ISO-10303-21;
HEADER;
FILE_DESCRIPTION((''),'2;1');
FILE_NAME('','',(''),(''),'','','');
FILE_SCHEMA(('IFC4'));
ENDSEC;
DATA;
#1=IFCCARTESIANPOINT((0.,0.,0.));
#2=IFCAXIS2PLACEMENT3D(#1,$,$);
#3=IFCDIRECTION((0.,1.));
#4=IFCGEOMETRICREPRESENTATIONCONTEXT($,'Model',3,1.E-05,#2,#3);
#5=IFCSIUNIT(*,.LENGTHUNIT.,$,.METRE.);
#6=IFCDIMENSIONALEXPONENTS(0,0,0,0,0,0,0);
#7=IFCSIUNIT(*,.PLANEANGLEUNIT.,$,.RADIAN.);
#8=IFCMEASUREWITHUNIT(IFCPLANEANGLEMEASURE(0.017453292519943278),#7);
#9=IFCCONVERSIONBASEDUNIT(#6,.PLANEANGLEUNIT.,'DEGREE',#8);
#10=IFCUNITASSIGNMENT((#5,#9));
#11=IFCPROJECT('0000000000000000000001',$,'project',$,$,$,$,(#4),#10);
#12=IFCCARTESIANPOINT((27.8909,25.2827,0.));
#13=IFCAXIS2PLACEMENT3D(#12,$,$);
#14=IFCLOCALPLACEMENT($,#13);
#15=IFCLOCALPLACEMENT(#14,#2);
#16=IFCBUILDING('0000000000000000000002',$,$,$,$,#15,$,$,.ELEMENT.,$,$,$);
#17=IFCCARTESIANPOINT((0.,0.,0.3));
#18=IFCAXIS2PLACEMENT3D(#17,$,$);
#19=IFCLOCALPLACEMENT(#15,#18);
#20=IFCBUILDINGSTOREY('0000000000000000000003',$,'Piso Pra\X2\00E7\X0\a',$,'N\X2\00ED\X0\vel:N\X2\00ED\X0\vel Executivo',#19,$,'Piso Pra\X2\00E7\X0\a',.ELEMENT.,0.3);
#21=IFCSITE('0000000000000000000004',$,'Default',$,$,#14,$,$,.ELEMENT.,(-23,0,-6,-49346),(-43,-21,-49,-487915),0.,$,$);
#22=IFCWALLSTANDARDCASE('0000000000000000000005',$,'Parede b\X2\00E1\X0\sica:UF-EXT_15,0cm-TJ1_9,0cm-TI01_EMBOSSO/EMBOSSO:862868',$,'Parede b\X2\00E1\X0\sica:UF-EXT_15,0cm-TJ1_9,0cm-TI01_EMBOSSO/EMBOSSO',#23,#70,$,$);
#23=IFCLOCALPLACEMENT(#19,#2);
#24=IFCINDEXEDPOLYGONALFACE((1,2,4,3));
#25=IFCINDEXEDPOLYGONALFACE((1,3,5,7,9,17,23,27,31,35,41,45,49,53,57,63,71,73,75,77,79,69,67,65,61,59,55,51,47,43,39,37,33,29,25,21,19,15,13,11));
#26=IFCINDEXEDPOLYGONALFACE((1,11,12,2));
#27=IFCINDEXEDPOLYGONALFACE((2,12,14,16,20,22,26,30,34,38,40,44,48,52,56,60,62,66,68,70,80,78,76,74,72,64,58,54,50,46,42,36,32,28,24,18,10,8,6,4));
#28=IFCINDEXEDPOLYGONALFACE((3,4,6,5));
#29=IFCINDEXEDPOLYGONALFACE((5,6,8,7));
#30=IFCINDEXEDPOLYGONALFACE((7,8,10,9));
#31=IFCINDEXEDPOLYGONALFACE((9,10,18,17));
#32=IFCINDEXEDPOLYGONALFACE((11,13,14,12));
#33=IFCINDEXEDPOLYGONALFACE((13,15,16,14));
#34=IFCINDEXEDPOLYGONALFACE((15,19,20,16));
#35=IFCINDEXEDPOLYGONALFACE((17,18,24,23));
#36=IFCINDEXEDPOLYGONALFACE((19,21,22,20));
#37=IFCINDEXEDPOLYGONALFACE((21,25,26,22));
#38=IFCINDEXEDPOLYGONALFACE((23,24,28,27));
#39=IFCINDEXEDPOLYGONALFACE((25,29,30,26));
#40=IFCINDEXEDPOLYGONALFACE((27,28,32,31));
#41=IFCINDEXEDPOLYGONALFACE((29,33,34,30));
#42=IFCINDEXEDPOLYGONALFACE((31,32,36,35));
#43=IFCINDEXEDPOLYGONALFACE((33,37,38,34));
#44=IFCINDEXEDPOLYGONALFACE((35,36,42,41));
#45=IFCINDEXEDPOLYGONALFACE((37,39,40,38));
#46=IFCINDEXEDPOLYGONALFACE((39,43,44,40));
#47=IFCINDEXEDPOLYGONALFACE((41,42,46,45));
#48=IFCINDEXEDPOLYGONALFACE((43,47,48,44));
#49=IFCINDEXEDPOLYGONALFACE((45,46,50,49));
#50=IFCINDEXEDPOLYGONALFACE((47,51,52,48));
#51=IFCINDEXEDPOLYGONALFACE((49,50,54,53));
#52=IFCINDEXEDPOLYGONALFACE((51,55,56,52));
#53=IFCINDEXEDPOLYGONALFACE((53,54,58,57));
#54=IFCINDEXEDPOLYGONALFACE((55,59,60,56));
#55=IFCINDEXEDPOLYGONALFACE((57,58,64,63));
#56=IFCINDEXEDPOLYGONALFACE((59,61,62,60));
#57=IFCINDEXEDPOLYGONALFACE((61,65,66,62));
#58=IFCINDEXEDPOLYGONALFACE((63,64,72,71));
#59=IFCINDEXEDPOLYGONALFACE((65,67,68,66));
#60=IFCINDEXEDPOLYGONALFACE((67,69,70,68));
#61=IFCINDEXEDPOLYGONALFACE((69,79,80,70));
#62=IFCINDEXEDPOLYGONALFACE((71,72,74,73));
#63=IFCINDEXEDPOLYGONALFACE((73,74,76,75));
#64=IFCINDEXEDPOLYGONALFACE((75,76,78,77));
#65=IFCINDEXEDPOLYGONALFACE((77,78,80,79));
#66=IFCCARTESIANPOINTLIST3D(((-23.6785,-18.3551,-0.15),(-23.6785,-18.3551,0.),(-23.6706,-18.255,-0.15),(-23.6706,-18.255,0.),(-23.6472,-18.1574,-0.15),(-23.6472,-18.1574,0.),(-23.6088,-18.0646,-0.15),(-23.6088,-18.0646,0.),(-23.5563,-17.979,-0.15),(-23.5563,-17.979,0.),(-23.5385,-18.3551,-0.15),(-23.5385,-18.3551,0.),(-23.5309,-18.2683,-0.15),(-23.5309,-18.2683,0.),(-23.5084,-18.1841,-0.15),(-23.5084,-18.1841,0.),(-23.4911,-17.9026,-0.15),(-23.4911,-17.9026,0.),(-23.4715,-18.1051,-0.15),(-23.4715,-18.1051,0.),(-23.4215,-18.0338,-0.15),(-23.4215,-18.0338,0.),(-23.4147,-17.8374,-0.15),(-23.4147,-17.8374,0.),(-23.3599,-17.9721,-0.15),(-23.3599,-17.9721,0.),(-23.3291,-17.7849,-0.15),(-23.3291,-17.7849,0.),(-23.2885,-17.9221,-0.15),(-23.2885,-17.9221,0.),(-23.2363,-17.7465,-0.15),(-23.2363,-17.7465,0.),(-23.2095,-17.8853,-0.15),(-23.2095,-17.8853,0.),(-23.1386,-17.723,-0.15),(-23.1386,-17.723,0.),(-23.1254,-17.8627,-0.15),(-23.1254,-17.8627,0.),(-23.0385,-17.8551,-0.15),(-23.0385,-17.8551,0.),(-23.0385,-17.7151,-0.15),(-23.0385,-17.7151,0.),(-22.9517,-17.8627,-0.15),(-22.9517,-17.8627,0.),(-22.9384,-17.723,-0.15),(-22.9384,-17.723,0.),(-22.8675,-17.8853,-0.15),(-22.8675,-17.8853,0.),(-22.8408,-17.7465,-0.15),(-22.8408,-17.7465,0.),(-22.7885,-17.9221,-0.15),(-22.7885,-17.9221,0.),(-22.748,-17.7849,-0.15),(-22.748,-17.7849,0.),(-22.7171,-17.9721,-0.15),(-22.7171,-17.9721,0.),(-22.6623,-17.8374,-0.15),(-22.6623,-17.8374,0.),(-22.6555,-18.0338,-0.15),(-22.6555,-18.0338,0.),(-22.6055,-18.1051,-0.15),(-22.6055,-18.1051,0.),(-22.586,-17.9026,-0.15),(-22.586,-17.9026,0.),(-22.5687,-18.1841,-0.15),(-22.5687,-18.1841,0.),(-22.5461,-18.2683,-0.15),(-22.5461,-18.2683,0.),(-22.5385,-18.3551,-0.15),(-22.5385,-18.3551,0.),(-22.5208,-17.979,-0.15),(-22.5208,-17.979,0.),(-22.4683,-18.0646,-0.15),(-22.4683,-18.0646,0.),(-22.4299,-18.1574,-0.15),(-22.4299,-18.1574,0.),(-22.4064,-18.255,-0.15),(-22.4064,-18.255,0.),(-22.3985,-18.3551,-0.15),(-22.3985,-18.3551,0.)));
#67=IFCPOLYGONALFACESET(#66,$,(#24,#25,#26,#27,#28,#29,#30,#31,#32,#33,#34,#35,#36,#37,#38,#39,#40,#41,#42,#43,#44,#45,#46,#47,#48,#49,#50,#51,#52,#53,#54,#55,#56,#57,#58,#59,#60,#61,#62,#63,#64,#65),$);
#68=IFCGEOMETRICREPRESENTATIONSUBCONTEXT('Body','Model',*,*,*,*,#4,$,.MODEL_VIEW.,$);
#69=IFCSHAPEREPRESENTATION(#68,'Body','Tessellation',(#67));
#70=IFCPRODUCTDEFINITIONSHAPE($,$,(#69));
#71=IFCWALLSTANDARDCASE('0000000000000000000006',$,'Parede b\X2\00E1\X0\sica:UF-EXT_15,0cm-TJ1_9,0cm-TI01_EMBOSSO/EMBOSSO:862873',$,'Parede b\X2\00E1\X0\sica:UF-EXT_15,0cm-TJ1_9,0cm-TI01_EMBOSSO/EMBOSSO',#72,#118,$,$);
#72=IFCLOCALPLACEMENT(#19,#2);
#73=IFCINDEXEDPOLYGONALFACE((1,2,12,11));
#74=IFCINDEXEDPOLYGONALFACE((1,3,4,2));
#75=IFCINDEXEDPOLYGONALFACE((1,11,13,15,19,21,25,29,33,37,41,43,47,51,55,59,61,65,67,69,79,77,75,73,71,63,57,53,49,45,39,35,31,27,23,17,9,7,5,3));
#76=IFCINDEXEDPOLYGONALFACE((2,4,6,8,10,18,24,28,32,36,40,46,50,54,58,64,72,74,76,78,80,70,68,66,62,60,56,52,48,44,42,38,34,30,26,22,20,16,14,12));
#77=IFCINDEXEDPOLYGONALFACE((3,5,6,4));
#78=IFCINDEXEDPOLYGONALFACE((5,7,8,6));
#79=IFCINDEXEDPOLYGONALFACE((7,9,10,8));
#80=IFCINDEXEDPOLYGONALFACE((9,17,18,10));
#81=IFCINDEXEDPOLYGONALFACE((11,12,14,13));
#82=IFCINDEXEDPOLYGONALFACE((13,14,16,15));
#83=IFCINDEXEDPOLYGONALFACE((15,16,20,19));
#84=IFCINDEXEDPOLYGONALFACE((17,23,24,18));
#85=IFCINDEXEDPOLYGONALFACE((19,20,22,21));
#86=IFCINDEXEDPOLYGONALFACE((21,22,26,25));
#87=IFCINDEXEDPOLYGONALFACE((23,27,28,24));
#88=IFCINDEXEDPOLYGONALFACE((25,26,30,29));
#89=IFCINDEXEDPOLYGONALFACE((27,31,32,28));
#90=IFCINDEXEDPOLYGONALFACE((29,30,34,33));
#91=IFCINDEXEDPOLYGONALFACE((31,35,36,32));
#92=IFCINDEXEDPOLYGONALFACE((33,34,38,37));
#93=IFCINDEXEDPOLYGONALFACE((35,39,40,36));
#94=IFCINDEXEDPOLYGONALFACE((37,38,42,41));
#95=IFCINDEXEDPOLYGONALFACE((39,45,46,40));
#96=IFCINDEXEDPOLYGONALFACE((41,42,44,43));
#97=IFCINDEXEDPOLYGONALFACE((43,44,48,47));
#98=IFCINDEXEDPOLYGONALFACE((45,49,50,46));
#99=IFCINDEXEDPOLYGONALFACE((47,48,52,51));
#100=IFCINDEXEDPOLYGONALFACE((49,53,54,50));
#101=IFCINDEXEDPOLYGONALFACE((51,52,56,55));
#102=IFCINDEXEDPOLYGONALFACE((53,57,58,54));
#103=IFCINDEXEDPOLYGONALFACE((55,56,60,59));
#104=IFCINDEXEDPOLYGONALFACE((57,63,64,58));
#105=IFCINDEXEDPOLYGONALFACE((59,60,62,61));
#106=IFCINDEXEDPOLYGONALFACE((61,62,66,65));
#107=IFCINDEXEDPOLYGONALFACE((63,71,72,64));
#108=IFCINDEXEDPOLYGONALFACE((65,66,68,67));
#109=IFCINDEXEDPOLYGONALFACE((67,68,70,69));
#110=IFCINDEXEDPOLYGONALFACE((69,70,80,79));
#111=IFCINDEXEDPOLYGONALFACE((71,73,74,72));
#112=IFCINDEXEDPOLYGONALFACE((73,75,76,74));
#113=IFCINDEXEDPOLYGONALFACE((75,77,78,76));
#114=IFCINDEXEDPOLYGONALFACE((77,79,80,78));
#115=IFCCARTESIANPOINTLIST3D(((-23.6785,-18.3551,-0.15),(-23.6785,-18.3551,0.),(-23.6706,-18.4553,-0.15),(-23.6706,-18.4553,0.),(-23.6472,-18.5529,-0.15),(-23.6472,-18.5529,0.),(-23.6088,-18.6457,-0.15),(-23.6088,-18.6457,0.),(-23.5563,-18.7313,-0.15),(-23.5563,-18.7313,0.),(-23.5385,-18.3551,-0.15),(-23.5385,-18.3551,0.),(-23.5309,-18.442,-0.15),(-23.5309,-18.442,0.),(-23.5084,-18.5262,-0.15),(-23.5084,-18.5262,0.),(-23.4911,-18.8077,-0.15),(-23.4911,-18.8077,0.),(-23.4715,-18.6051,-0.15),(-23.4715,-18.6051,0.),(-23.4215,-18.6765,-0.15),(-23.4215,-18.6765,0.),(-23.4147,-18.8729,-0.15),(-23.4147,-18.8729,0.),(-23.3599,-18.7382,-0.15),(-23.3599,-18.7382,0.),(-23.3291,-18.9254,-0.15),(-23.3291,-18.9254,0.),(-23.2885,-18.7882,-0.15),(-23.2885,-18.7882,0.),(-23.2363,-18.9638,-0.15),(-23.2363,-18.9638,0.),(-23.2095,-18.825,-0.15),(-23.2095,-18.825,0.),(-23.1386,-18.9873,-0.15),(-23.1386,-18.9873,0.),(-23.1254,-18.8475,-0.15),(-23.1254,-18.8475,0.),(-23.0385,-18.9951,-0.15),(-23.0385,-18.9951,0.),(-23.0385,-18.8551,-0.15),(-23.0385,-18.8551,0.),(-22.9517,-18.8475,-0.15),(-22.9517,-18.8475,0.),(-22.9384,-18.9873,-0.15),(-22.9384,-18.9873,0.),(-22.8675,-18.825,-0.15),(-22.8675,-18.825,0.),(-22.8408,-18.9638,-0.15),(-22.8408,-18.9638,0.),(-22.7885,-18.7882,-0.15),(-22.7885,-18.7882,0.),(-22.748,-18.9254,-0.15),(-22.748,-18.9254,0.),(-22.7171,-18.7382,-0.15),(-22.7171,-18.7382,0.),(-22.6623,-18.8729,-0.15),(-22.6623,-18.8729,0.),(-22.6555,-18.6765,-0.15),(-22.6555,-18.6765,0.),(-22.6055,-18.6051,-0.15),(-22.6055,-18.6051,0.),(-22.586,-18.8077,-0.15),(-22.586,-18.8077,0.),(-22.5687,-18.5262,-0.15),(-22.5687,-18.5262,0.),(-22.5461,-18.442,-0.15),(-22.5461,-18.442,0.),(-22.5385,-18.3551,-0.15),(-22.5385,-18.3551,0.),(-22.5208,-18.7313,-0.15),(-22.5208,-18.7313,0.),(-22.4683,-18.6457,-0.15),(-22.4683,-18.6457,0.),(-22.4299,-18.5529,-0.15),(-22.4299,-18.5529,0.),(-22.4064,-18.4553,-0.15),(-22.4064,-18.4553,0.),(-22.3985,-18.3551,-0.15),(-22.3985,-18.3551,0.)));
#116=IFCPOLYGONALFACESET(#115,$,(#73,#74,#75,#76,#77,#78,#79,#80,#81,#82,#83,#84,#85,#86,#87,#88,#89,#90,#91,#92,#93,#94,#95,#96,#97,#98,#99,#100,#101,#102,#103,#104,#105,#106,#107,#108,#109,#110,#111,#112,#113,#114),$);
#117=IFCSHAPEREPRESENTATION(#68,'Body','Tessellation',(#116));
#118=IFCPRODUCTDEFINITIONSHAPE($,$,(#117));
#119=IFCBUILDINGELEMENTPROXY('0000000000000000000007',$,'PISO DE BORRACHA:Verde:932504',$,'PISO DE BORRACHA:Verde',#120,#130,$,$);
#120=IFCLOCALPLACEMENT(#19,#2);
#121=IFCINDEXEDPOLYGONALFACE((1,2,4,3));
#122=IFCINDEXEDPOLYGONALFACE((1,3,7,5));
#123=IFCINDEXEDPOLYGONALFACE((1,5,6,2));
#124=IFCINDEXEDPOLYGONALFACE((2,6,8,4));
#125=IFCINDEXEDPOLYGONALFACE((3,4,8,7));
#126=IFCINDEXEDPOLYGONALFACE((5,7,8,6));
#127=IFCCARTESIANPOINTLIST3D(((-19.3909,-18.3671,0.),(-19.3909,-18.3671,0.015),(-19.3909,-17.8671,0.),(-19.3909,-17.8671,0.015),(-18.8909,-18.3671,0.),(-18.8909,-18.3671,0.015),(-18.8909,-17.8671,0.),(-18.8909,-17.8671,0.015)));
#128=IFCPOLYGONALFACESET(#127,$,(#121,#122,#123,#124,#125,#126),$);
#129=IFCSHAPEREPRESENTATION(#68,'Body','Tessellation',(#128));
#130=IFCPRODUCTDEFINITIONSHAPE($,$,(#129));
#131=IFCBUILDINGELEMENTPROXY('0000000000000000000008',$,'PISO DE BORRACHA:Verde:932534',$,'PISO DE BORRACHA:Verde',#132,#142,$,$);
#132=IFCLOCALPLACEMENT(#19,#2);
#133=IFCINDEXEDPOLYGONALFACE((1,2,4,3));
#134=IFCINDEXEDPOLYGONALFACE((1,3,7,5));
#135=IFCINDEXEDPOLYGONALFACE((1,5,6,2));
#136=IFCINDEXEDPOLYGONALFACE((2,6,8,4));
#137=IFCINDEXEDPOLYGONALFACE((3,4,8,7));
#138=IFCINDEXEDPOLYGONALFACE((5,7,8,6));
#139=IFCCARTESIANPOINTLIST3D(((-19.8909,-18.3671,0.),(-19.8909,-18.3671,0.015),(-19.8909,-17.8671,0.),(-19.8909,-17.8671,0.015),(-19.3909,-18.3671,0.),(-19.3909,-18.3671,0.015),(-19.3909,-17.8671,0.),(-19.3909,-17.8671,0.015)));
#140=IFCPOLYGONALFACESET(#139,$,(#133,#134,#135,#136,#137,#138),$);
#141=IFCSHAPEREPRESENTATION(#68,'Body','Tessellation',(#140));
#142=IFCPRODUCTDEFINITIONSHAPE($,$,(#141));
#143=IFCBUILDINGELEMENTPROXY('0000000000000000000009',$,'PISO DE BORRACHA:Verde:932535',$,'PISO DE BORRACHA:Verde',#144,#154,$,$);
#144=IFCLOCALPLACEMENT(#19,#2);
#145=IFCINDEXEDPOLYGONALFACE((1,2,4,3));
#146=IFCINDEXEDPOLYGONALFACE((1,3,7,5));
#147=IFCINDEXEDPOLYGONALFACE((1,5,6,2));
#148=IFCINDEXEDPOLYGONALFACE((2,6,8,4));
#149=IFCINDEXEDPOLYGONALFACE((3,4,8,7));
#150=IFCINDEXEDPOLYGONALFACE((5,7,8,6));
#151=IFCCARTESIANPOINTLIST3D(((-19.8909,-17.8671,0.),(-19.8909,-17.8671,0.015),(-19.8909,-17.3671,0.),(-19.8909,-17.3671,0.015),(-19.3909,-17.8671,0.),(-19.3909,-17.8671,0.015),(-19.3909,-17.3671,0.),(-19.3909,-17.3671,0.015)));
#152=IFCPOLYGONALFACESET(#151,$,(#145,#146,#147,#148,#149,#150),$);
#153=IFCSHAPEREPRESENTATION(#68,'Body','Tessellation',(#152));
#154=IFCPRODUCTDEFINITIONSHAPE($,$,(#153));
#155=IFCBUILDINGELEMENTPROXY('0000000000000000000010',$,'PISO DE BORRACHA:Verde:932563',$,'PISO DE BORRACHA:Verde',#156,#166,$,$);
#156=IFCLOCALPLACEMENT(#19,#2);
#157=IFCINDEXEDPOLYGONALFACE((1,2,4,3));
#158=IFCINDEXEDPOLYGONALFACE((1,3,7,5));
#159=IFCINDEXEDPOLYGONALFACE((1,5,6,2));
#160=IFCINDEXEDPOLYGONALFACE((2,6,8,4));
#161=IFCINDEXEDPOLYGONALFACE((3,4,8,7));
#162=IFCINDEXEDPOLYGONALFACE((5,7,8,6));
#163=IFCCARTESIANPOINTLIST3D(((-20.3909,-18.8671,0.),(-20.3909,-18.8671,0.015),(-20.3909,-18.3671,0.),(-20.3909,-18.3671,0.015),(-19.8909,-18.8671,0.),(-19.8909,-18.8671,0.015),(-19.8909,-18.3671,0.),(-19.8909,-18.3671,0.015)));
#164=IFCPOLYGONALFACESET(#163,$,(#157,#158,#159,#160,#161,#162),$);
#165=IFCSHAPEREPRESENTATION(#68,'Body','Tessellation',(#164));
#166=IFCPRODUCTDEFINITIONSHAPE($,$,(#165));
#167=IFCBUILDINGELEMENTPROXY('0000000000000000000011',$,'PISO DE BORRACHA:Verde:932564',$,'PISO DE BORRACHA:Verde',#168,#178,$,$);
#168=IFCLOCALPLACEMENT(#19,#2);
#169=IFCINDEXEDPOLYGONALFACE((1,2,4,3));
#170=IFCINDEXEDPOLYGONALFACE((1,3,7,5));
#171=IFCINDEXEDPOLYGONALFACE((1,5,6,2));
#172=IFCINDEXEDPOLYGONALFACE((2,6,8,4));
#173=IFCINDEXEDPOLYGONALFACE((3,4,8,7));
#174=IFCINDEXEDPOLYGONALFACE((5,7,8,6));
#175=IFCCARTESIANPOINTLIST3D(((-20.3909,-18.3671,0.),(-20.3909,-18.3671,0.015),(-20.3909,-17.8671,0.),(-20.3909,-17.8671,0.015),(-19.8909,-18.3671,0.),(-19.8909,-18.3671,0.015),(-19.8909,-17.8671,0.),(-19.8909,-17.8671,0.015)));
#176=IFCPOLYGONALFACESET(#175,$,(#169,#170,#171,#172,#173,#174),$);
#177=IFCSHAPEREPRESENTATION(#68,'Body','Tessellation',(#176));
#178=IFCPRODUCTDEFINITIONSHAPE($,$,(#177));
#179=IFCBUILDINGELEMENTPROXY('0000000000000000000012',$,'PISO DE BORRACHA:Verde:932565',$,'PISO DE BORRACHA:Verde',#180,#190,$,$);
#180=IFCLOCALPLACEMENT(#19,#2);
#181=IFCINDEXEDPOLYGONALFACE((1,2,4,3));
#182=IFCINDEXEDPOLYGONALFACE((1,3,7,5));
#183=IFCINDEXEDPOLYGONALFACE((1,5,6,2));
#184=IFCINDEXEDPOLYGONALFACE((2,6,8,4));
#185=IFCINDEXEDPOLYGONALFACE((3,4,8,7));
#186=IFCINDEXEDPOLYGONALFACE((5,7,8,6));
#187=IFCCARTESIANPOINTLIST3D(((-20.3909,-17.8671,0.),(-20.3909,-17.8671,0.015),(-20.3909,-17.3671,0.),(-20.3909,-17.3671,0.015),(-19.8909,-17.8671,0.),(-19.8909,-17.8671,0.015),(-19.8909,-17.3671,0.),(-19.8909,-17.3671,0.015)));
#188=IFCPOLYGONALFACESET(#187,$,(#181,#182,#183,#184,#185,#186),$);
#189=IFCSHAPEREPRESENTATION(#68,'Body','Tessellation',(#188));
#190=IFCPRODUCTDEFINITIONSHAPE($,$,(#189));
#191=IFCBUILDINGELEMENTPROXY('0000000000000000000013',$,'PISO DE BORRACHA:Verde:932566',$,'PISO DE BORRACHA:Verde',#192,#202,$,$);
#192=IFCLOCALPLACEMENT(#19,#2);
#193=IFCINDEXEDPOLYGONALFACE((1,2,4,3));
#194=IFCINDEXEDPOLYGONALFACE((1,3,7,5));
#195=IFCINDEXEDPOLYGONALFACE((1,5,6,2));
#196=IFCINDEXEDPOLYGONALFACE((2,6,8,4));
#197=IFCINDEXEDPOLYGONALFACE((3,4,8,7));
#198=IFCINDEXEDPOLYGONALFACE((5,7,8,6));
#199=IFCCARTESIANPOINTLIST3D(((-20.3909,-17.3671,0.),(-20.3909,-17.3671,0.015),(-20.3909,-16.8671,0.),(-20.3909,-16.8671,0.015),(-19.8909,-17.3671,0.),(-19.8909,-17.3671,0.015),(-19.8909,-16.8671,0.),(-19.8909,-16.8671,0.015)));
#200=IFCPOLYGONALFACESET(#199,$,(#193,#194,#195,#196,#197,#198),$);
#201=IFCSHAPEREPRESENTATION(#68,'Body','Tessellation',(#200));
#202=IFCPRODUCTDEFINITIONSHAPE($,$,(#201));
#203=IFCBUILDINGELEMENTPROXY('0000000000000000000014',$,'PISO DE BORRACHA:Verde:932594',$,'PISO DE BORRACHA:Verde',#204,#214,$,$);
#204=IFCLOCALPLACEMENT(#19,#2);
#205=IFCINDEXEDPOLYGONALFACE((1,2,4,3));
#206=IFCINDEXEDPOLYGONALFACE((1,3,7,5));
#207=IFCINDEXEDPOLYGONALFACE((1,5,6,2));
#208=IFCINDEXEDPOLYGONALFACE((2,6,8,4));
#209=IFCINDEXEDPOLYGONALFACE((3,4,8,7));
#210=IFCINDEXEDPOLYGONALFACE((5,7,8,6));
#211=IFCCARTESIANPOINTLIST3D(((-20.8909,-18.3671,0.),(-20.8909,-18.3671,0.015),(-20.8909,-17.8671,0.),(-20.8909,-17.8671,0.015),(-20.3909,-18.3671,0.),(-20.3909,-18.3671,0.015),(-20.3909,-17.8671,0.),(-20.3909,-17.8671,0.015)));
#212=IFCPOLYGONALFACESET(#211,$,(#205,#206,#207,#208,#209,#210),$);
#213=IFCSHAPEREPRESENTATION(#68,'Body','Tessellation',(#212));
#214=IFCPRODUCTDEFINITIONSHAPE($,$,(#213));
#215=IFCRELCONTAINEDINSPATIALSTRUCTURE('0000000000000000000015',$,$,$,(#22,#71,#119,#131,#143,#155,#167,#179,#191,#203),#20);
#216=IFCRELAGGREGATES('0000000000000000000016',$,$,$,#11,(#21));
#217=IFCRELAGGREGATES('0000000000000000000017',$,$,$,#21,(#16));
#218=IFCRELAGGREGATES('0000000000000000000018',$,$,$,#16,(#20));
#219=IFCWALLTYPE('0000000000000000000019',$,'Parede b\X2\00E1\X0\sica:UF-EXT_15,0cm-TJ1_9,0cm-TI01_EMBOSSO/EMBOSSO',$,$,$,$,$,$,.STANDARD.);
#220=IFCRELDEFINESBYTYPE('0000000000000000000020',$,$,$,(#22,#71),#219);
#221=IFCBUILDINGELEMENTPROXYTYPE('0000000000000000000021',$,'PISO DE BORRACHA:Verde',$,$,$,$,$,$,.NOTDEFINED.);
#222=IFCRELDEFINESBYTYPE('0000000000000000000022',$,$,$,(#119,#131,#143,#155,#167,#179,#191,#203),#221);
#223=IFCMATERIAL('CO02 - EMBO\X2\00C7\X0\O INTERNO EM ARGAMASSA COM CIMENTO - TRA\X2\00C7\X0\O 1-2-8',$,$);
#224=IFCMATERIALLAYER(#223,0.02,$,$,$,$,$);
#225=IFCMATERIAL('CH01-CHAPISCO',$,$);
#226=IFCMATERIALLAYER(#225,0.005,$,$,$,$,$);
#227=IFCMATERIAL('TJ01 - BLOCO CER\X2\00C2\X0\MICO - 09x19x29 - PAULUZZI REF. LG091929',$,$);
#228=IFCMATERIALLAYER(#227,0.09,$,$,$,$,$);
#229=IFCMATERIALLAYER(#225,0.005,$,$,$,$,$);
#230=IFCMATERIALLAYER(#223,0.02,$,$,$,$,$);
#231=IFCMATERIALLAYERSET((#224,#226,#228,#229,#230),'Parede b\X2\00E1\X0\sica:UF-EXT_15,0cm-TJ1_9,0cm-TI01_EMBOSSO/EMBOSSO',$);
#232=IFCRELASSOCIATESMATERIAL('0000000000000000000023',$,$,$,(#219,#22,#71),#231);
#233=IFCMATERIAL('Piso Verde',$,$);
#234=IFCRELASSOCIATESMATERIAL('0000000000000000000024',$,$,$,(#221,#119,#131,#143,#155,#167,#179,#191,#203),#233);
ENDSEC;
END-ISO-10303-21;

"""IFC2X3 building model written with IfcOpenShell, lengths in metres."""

from ifc_helpers import new_model, entity, si_unit, converted_unit, direction, frame, frame_2d, origin, origin_2d_with_axis, place, context, subcontext, project, spatial, polyline, circle_curve, parameter, trimmed, segment, composite_curve, rectangle, outline, extrude, source, transform, mapped, material, layer, layer_set, layer_usage, type_object, type_shapes, element, save


model = new_model("IFC2X3")

# Units and contexts
model_context = context("Model", 3, precision=1e-05, world=origin(), true_north=direction((0.0, 1.0)))
body_context = subcontext(model_context, "Body", "Model", "MODEL_VIEW")
ifc_project = project(units=[si_unit("LENGTHUNIT", "METRE"), converted_unit("PLANEANGLEUNIT", "DEGREE", entity("IfcPlaneAngleMeasure", 0.017453292519943278), si_unit("PLANEANGLEUNIT", "RADIAN"), dimensions=[0, 0, 0, 0, 0, 0, 0])], contexts=[model_context])

# Site, building, storey
site_placement = place(None, frame((27.8909, 25.2827, 0.0)))
site = spatial("IfcSite", under=ifc_project, at=site_placement, Name="Default", CompositionType="ELEMENT", RefLatitude=(-23, 0, -6, -49346), RefLongitude=(-43, -21, -49, -487915), RefElevation=0.0)
building_placement = place(site_placement, origin())
building = spatial("IfcBuilding", under=site, at=building_placement, CompositionType="ELEMENT")
storey_placement = place(building_placement, frame((0.0, 0.0, 0.3)))
storey = spatial("IfcBuildingStorey", under=building, at=storey_placement, Name="Piso Praça", ObjectType="Nível:Nível Executivo", LongName="Piso Praça", CompositionType="ELEMENT", Elevation=0.3)

# Walls
ifc_material_1 = material(Name="CO02 - EMBOÇO INTERNO EM ARGAMASSA COM CIMENTO - TRAÇO 1-2-8")
ifc_layer_1 = layer(ifc_material_1, 0.02)
ifc_material_2 = material(Name="CH01-CHAPISCO")
ifc_layer_2 = layer(ifc_material_2, 0.005)
ifc_material_3 = material(Name="TJ01 - BLOCO CERÂMICO - 09x19x29 - PAULUZZI REF. LG091929")
ifc_layer_3 = layer(ifc_material_3, 0.09)
ifc_layer_4 = layer(ifc_material_2, 0.005)
ifc_layer_5 = layer(ifc_material_1, 0.02)
ifc_layer_set_1 = layer_set([ifc_layer_1, ifc_layer_2, ifc_layer_3, ifc_layer_4, ifc_layer_5], Name="Parede básica:UF-EXT_15,0cm-TJ1_9,0cm-TI01_EMBOSSO/EMBOSSO")
ifc_layer_usage_1 = layer_usage(ifc_layer_set_1, "AXIS2", "NEGATIVE", 0.07)
wall_type_1 = type_object("IfcWallType", Name="Parede básica:UF-EXT_15,0cm-TJ1_9,0cm-TI01_EMBOSSO/EMBOSSO", PredefinedType="STANDARD", material=ifc_layer_set_1)
wall_1_placement = place(storey_placement, frame((-22.4685, -18.3551, -0.15)))
element("IfcWallStandardCase", 1, at=wall_1_placement, inside=storey, type_object=wall_type_1, material=ifc_layer_usage_1, Name="Parede básica:UF-EXT_15,0cm-TJ1_9,0cm-TI01_EMBOSSO/EMBOSSO:862868", ObjectType="Parede básica:UF-EXT_15,0cm-TJ1_9,0cm-TI01_EMBOSSO/EMBOSSO", context=body_context, shape_type="SweptSolid", body=[
    extrude(outline(composite_curve([segment(trimmed(circle_curve(frame_2d((-0.57, 0.0), x_axis=(1.0, 0.0)), 0.5), [parameter(0.0)], [parameter(180.0)], True, "PARAMETER"), False, "CONTINUOUS"), segment(polyline([(-0.07, 0.0), (0.07, 0.0)]), True, "CONTINUOUS"), segment(trimmed(circle_curve(frame_2d((-0.57, 0.0), x_axis=(1.0, 0.0)), 0.64), [parameter(0.0)], [parameter(180.0)], True, "PARAMETER"), True, "CONTINUOUS"), segment(polyline([(-1.21, 0.0), (-1.07, 0.0)]), True, "CONTINUOUS")], self_intersect=False)), origin(), (0.0, 0.0, 1.0), 0.15),
])
wall_2_placement = place(storey_placement, frame((-23.6085, -18.3551, -0.15)))
element("IfcWallStandardCase", 2, at=wall_2_placement, inside=storey, type_object=wall_type_1, material=ifc_layer_usage_1, Name="Parede básica:UF-EXT_15,0cm-TJ1_9,0cm-TI01_EMBOSSO/EMBOSSO:862873", ObjectType="Parede básica:UF-EXT_15,0cm-TJ1_9,0cm-TI01_EMBOSSO/EMBOSSO", context=body_context, shape_type="SweptSolid", body=[
    extrude(outline(composite_curve([segment(trimmed(circle_curve(frame_2d((0.57, 0.0), x_axis=(1.0, 0.0)), 0.5), [parameter(180.0)], [parameter(0.0)], True, "PARAMETER"), False, "CONTINUOUS"), segment(polyline([(0.07, 0.0), (-0.07, 0.0)]), True, "CONTINUOUS"), segment(trimmed(circle_curve(frame_2d((0.57, 0.0), x_axis=(1.0, 0.0)), 0.64), [parameter(180.0)], [parameter(0.0)], True, "PARAMETER"), True, "CONTINUOUS"), segment(polyline([(1.21, 0.0), (1.07, 0.0)]), True, "CONTINUOUS")], self_intersect=False)), origin(), (0.0, 0.0, 1.0), 0.15),
])

# Building element proxies
ifc_material_4 = material(Name="Piso Verde")
building_element_proxy_type_1 = type_object("IfcBuildingElementProxyType", Name="PISO DE BORRACHA:Verde", PredefinedType="NOTDEFINED", material=ifc_material_4)
shared_shape_1 = source(origin(), body_context, "Body", "SweptSolid", [
    extrude(rectangle(XDim=0.5, YDim=0.5, at=origin_2d_with_axis()), frame((0.25, 0.25, 0.0), z_axis=(0.0, 0.0, 1.0), x_axis=(-1.0, 0.0, 0.0)), (0.0, 0.0, 1.0), 0.015),
])
type_shapes(building_element_proxy_type_1, [shared_shape_1])
for number, where, z_axis, x_axis, name in (
    (3, (-19.3909, -17.8671, 0.0), (0.0, 0.0, 1.0), (0.0, -1.0, 0.0), "PISO DE BORRACHA:Verde:932504"),
    (4, (-19.8909, -17.8671, 0.0), (0.0, 0.0, 1.0), (0.0, -1.0, 0.0), "PISO DE BORRACHA:Verde:932534"),
    (5, (-19.8909, -17.3671, 0.0), (0.0, 0.0, 1.0), (0.0, -1.0, 0.0), "PISO DE BORRACHA:Verde:932535"),
    (6, (-20.3909, -18.3671, 0.0), (0.0, 0.0, 1.0), (0.0, -1.0, 0.0), "PISO DE BORRACHA:Verde:932563"),
    (7, (-20.3909, -17.8671, 0.0), (0.0, 0.0, 1.0), (0.0, -1.0, 0.0), "PISO DE BORRACHA:Verde:932564"),
    (8, (-20.3909, -17.3671, 0.0), (0.0, 0.0, 1.0), (0.0, -1.0, 0.0), "PISO DE BORRACHA:Verde:932565"),
    (9, (-20.3909, -16.8671, 0.0), (0.0, 0.0, 1.0), (0.0, -1.0, 0.0), "PISO DE BORRACHA:Verde:932566"),
    (10, (-20.8909, -17.8671, 0.0), (0.0, 0.0, 1.0), (0.0, -1.0, 0.0), "PISO DE BORRACHA:Verde:932594"),
):
    element("IfcBuildingElementProxy", number, at=place(storey_placement, frame(where, z_axis=z_axis, x_axis=x_axis)), inside=storey, type_object=building_element_proxy_type_1, material=ifc_material_4, Name=name, ObjectType="PISO DE BORRACHA:Verde", context=body_context, shape_type="MappedRepresentation", body=[
        mapped(shared_shape_1, transform((0.0, 0.0, 0.0), scale=1.0)),
    ])

save(model, "model.ifc")
